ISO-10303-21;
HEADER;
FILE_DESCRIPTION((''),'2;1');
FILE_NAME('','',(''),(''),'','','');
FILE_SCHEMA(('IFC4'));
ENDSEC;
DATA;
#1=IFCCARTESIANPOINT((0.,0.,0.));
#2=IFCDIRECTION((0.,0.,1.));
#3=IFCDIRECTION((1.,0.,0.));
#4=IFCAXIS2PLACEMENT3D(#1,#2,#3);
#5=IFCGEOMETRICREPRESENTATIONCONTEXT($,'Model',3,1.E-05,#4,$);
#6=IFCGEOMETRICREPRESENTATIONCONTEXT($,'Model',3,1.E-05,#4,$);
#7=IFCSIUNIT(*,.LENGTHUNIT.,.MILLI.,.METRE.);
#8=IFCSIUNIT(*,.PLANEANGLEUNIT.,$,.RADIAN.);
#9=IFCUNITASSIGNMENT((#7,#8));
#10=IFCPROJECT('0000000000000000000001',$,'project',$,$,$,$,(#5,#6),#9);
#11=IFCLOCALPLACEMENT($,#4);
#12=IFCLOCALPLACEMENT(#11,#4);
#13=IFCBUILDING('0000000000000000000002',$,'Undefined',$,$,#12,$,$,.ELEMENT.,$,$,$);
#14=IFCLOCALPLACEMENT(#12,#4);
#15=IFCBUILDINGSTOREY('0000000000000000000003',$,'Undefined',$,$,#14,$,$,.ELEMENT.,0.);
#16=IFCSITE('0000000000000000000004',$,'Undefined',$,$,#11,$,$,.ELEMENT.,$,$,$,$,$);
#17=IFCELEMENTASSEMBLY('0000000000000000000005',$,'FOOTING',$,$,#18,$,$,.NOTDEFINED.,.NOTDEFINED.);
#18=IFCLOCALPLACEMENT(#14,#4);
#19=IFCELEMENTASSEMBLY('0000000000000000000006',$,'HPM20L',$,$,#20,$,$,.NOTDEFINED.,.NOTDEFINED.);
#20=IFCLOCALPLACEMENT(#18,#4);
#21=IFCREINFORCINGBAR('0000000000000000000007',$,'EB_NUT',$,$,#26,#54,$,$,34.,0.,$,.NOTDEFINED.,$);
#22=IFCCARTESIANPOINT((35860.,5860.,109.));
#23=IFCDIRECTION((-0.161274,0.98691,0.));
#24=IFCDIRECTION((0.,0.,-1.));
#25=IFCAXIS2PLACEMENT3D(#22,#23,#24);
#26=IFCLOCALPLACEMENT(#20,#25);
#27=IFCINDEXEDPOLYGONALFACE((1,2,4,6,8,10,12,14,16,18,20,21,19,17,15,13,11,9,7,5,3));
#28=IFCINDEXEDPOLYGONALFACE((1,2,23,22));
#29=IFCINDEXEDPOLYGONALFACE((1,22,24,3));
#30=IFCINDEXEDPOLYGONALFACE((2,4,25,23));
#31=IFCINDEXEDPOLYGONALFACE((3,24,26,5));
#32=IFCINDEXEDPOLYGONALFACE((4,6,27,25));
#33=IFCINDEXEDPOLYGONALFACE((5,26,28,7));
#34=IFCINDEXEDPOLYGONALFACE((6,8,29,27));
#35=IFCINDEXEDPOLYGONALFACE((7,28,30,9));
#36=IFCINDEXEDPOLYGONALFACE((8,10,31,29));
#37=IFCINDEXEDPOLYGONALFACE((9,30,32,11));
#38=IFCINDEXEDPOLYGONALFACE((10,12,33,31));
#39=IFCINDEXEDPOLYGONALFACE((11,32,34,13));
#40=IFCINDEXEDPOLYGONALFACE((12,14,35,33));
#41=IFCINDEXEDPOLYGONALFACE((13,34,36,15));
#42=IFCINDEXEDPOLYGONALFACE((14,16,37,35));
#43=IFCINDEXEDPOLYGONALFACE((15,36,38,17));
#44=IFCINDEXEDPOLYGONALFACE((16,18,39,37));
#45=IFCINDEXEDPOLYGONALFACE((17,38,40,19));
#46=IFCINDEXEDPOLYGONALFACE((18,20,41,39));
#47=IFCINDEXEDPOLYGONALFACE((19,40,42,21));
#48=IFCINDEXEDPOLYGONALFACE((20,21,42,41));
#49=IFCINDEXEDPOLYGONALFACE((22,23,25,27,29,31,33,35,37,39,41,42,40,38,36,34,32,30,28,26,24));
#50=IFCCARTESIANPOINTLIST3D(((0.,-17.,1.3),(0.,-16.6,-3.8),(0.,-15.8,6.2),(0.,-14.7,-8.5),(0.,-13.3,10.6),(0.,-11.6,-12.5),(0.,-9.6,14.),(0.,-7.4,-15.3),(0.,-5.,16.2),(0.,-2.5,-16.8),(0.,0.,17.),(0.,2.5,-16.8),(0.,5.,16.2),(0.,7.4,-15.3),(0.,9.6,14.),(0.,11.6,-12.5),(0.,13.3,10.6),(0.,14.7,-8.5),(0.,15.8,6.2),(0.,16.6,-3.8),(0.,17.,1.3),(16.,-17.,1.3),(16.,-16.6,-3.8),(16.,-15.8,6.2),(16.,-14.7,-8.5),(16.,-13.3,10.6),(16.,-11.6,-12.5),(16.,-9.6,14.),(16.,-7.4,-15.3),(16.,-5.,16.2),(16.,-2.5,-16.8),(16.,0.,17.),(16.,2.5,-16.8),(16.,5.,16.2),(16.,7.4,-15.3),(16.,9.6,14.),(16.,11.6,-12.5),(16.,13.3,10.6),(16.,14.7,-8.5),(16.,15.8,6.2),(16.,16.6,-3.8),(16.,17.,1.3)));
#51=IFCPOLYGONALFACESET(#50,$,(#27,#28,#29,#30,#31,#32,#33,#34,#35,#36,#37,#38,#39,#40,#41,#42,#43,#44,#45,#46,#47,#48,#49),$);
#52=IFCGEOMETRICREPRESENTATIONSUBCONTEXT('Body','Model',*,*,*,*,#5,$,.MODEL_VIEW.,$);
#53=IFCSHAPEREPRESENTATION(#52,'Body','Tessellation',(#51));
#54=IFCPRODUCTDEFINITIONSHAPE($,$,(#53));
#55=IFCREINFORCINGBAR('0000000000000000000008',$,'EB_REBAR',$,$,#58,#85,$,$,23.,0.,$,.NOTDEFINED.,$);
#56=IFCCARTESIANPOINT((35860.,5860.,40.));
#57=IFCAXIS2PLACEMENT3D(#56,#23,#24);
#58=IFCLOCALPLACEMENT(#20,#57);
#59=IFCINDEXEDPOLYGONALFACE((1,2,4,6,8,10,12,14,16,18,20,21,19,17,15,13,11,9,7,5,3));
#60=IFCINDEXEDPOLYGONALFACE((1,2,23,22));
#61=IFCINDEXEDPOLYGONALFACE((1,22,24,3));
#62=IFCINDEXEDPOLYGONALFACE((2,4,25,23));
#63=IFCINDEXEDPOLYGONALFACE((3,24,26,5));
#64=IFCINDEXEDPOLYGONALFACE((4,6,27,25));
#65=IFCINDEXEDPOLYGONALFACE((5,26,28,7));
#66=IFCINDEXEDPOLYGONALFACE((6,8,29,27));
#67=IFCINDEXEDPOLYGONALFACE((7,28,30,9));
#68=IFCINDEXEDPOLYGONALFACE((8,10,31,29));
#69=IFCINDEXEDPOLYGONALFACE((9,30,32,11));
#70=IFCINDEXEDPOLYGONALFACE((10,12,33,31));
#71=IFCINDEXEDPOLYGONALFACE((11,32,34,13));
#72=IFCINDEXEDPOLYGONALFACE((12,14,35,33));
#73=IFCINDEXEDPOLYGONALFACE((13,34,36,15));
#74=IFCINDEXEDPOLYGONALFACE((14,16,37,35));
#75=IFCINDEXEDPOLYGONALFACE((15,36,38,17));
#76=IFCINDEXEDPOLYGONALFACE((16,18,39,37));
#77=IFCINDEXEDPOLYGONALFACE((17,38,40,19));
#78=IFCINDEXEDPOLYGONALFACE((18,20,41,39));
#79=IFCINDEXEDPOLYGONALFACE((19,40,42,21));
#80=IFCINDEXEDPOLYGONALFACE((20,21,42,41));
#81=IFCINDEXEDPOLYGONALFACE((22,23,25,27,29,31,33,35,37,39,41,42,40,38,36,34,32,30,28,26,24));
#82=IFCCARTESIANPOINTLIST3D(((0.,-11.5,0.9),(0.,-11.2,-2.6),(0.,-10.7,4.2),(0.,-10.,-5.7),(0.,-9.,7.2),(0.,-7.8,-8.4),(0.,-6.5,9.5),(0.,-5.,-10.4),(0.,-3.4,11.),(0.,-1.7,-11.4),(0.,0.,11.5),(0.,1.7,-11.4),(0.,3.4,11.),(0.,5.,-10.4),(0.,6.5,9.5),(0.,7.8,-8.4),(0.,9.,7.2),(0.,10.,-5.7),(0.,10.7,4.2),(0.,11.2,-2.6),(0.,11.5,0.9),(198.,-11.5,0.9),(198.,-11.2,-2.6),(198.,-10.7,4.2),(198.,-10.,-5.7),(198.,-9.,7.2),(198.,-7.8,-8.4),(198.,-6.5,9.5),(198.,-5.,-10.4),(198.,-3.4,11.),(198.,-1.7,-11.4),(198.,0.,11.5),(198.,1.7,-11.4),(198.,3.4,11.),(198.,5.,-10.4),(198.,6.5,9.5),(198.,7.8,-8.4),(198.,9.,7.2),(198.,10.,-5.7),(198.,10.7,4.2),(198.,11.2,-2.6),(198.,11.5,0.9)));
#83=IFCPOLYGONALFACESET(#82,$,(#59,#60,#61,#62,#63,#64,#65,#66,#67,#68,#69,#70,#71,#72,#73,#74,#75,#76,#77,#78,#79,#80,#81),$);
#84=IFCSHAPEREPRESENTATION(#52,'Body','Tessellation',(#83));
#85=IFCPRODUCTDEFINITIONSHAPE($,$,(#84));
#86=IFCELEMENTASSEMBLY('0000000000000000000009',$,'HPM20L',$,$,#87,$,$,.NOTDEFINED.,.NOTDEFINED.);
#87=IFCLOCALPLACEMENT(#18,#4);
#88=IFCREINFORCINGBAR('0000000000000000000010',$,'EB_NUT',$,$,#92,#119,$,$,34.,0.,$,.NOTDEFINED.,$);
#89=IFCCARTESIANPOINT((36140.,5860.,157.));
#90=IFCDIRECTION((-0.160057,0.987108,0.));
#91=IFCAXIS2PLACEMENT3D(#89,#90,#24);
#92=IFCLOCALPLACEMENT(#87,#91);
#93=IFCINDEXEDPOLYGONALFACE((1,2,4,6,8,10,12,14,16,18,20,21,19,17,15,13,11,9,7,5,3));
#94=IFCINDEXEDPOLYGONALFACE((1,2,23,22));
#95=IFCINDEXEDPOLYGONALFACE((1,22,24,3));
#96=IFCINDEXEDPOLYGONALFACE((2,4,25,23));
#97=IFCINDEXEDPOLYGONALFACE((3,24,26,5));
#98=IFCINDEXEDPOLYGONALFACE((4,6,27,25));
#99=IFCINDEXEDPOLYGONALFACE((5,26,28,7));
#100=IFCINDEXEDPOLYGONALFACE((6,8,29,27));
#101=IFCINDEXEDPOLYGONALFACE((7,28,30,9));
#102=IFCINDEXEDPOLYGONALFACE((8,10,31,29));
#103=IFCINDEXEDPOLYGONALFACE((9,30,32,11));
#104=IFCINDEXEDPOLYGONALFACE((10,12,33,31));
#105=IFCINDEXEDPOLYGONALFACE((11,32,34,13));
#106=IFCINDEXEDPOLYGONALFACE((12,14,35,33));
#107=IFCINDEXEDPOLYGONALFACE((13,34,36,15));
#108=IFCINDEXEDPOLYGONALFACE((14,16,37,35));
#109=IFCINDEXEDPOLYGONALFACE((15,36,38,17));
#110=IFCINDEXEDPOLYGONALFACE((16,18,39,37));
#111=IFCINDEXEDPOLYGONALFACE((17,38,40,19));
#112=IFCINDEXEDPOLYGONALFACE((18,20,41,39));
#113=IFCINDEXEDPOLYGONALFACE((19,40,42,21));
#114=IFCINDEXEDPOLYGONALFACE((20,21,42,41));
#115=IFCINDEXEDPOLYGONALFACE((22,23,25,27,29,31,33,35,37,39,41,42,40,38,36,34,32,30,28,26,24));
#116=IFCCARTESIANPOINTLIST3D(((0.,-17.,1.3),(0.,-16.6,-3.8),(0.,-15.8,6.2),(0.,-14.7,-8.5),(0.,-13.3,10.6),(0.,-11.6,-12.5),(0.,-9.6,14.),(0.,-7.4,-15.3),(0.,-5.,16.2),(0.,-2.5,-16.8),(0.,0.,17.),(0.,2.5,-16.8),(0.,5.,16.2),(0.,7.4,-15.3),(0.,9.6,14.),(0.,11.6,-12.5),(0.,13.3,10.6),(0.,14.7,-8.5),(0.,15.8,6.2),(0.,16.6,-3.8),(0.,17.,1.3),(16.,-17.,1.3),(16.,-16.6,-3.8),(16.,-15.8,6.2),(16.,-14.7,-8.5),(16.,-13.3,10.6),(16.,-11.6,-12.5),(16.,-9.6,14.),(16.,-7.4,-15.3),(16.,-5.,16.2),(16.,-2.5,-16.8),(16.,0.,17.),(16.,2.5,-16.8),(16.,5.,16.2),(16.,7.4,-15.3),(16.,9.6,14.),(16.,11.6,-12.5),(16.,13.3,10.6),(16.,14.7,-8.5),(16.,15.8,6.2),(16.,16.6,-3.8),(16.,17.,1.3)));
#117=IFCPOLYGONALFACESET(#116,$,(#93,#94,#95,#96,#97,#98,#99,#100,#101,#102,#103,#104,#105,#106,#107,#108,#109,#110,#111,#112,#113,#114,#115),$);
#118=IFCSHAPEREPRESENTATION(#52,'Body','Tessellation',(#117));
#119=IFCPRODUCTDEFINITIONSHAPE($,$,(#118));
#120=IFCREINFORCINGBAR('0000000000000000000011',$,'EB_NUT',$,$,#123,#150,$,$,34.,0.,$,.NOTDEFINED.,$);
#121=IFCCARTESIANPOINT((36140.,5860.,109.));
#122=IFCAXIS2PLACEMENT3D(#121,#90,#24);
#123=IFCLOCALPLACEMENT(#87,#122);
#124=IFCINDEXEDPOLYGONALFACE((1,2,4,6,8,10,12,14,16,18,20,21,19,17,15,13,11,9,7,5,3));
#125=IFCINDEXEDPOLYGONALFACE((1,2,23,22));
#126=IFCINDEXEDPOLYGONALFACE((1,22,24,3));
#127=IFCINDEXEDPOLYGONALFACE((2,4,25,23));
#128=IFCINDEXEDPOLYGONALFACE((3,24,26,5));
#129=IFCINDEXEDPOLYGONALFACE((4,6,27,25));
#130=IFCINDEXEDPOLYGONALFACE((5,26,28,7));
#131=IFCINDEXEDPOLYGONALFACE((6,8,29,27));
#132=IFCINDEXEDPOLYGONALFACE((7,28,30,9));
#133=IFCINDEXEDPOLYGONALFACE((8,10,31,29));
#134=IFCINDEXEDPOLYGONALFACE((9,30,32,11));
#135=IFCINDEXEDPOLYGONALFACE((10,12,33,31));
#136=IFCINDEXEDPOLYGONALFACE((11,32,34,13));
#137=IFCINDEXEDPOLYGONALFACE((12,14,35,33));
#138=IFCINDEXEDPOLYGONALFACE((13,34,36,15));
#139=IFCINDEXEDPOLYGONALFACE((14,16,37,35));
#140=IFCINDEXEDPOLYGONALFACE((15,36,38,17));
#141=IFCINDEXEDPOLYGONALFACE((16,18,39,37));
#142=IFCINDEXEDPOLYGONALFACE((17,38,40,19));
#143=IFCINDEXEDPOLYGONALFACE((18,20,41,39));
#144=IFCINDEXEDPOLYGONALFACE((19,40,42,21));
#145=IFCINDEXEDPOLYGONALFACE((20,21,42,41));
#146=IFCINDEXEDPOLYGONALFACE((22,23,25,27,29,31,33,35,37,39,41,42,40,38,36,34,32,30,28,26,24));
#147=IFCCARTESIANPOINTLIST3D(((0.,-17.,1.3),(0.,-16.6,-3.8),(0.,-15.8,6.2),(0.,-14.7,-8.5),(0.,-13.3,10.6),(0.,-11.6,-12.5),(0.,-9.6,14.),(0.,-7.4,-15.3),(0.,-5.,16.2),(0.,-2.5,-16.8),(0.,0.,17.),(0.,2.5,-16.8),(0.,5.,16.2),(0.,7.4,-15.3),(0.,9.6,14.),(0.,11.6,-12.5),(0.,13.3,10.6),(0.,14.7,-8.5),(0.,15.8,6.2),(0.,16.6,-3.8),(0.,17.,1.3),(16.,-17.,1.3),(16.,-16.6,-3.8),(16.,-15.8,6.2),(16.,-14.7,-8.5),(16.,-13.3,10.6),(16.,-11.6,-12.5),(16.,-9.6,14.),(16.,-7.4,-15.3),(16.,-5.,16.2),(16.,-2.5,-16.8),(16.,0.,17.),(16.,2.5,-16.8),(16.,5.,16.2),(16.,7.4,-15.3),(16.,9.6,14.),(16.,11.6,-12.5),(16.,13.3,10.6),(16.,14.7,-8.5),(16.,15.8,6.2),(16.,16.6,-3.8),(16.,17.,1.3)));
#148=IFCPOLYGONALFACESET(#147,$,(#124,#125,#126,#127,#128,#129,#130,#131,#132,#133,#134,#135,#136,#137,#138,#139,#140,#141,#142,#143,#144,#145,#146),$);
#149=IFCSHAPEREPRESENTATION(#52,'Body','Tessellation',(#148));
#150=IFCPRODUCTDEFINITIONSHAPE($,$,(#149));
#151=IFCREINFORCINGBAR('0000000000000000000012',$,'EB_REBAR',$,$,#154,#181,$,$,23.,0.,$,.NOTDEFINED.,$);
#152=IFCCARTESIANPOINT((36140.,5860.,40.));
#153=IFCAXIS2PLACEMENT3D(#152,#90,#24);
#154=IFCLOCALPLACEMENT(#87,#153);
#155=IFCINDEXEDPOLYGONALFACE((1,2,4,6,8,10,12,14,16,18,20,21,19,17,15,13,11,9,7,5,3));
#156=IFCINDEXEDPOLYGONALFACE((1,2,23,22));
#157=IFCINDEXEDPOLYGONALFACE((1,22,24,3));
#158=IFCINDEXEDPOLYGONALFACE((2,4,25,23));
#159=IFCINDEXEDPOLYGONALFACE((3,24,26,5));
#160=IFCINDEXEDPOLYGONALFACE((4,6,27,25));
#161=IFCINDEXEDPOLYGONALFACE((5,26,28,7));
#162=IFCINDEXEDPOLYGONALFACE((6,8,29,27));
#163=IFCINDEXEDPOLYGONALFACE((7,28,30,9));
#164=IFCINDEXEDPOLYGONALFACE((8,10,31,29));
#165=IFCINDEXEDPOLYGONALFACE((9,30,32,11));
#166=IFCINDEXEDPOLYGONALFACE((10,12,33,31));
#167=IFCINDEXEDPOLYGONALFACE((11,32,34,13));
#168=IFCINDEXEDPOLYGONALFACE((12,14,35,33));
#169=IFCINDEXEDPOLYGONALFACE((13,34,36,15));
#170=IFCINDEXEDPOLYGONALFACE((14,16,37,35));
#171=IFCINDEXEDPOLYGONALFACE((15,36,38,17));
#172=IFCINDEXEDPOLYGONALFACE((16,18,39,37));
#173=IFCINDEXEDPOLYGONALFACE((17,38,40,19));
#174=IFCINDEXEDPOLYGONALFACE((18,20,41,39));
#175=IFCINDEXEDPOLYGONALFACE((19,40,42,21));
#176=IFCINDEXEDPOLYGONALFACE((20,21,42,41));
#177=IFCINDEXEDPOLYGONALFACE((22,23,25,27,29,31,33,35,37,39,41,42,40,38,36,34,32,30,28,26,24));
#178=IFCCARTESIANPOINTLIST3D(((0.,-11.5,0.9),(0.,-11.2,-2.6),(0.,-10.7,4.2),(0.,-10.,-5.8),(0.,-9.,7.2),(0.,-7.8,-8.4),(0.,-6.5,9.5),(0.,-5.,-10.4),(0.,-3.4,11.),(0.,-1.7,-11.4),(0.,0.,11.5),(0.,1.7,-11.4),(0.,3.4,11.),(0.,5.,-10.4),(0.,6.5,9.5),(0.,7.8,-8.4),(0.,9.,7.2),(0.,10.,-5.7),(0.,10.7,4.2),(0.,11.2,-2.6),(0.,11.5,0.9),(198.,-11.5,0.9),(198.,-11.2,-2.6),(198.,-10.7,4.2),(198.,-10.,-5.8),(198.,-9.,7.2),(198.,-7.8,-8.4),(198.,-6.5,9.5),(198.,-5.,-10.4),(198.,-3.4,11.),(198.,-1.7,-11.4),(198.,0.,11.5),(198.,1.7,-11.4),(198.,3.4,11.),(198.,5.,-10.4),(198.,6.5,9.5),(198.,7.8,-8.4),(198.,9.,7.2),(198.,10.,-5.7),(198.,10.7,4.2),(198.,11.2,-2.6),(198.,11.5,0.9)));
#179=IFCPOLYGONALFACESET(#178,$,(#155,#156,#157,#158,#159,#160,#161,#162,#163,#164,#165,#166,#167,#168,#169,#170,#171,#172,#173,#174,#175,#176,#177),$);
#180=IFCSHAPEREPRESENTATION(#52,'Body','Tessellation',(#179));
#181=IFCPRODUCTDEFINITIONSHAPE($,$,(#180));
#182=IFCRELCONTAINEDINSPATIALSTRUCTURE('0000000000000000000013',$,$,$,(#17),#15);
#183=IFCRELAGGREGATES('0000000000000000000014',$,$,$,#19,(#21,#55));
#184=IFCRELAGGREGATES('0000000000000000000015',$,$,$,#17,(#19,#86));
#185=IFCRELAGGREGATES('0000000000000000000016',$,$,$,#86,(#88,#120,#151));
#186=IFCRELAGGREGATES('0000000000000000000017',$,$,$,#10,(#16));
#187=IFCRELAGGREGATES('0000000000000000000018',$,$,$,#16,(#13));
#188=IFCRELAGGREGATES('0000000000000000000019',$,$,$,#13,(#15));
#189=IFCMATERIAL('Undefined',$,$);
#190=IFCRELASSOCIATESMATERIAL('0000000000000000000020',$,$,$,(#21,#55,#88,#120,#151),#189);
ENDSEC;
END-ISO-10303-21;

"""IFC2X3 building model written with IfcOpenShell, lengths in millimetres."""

from ifc_helpers import new_model, entity, si_unit, frame, origin_with_axes, place, context, subcontext, project, spatial, source, transform, mapped, material, element, aggregate, save


model = new_model("IFC2X3")

# Units and contexts
model_context_1 = context("Model", 3, precision=1e-05, world=origin_with_axes())
model_context_2 = context("Model", 3, precision=1e-05, world=origin_with_axes())
body_context = subcontext(model_context_1, "Body", "Model", "MODEL_VIEW")
ifc_project = project(units=[si_unit("LENGTHUNIT", "METRE", prefix="MILLI"), si_unit("PLANEANGLEUNIT", "RADIAN")], contexts=[model_context_1, model_context_2])

# Site, building, storey
site_placement = place(None, origin_with_axes())
site = spatial("IfcSite", under=ifc_project, at=site_placement, Name="Undefined", CompositionType="ELEMENT")
building_placement = place(site_placement, origin_with_axes())
building = spatial("IfcBuilding", under=site, at=building_placement, Name="Undefined", CompositionType="ELEMENT")
storey_placement = place(building_placement, origin_with_axes())
storey = spatial("IfcBuildingStorey", under=building, at=storey_placement, Name="Undefined", CompositionType="ELEMENT", Elevation=0.0)

# Element assembly
assembly_1_placement = place(storey_placement, origin_with_axes())
assembly_1 = element("IfcElementAssembly", 1, at=assembly_1_placement, inside=storey, Name="FOOTING", AssemblyPlace="NOTDEFINED", PredefinedType="NOTDEFINED")

# Shared definitions
ifc_material_1 = material(Name="Undefined")

# Element assembly, reinforcing bars
assembly_2_placement = place(assembly_1_placement, origin_with_axes())
assembly_2 = element("IfcElementAssembly", 2, at=assembly_2_placement, Name="HPM20L", AssemblyPlace="NOTDEFINED", PredefinedType="NOTDEFINED")
shared_shape_1 = source(origin_with_axes(), body_context, "Body", "AdvancedSweptSolid", [
    entity("IfcSweptDiskSolid", entity("IfcTrimmedCurve", entity("IfcLine", entity("IfcCartesianPoint", [0.0, 0.0, 0.0]), entity("IfcVector", entity("IfcDirection", [1.0, 0.0, 0.0]), 1.0)), [entity("IfcParameterValue", 0.0)], [entity("IfcParameterValue", 16.0)], True, "PARAMETER"), 17.0, None, 0.0, 16.0),
])
reinforcing_bar_1_placement = place(assembly_2_placement, frame((35860.0, 5860.0, 109.0), z_axis=(-0.161274, 0.98691, 0.0), x_axis=(0.0, 0.0, -1.0)))
reinforcing_bar_1 = element("IfcReinforcingBar", 3, at=reinforcing_bar_1_placement, material=ifc_material_1, Name="EB_NUT", BarRole="NOTDEFINED", CrossSectionArea=0.0, NominalDiameter=34.0, context=body_context, shape_type="MappedRepresentation", body=[
    mapped(shared_shape_1, transform((0.0, 0.0, 0.0))),
])
shared_shape_2 = source(origin_with_axes(), body_context, "Body", "AdvancedSweptSolid", [
    entity("IfcSweptDiskSolid", entity("IfcTrimmedCurve", entity("IfcLine", entity("IfcCartesianPoint", [0.0, 0.0, 0.0]), entity("IfcVector", entity("IfcDirection", [1.0, 0.0, 0.0]), 1.0)), [entity("IfcParameterValue", 0.0)], [entity("IfcParameterValue", 198.0)], True, "PARAMETER"), 11.5, None, 0.0, 198.0),
])
reinforcing_bar_2_placement = place(assembly_2_placement, frame((35860.0, 5860.0, 40.0), z_axis=(-0.161274, 0.98691, 0.0), x_axis=(0.0, 0.0, -1.0)))
reinforcing_bar_2 = element("IfcReinforcingBar", 4, at=reinforcing_bar_2_placement, material=ifc_material_1, Name="EB_REBAR", BarRole="NOTDEFINED", CrossSectionArea=0.0, NominalDiameter=23.0, context=body_context, shape_type="MappedRepresentation", body=[
    mapped(shared_shape_2, transform((0.0, 0.0, 0.0))),
])
aggregate(assembly_2, [reinforcing_bar_1, reinforcing_bar_2])

# Element assembly
assembly_3_placement = place(assembly_1_placement, origin_with_axes())
assembly_3 = element("IfcElementAssembly", 5, at=assembly_3_placement, Name="HPM20L", AssemblyPlace="NOTDEFINED", PredefinedType="NOTDEFINED")
aggregate(assembly_1, [assembly_2, assembly_3])

# Reinforcing bars
shared_shape_3 = source(origin_with_axes(), body_context, "Body", "AdvancedSweptSolid", [
    entity("IfcSweptDiskSolid", entity("IfcTrimmedCurve", entity("IfcLine", entity("IfcCartesianPoint", [0.0, 0.0, 0.0]), entity("IfcVector", entity("IfcDirection", [1.0, 0.0, 0.0]), 1.0)), [entity("IfcParameterValue", 0.0)], [entity("IfcParameterValue", 16.0)], True, "PARAMETER"), 17.0, None, 0.0, 16.0),
])
reinforcing_bar_3_placement = place(assembly_3_placement, frame((36140.0, 5860.0, 157.0), z_axis=(-0.160057, 0.987108, 0.0), x_axis=(0.0, 0.0, -1.0)))
reinforcing_bar_3 = element("IfcReinforcingBar", 6, at=reinforcing_bar_3_placement, material=ifc_material_1, Name="EB_NUT", BarRole="NOTDEFINED", CrossSectionArea=0.0, NominalDiameter=34.0, context=body_context, shape_type="MappedRepresentation", body=[
    mapped(shared_shape_3, transform((0.0, 0.0, 0.0))),
])
shared_shape_4 = source(origin_with_axes(), body_context, "Body", "AdvancedSweptSolid", [
    entity("IfcSweptDiskSolid", entity("IfcTrimmedCurve", entity("IfcLine", entity("IfcCartesianPoint", [0.0, 0.0, 0.0]), entity("IfcVector", entity("IfcDirection", [1.0, 0.0, 0.0]), 1.0)), [entity("IfcParameterValue", 0.0)], [entity("IfcParameterValue", 16.0)], True, "PARAMETER"), 17.0, None, 0.0, 16.0),
])
reinforcing_bar_4_placement = place(assembly_3_placement, frame((36140.0, 5860.0, 109.0), z_axis=(-0.160057, 0.987108, 0.0), x_axis=(0.0, 0.0, -1.0)))
reinforcing_bar_4 = element("IfcReinforcingBar", 7, at=reinforcing_bar_4_placement, material=ifc_material_1, Name="EB_NUT", BarRole="NOTDEFINED", CrossSectionArea=0.0, NominalDiameter=34.0, context=body_context, shape_type="MappedRepresentation", body=[
    mapped(shared_shape_4, transform((0.0, 0.0, 0.0))),
])
shared_shape_5 = source(origin_with_axes(), body_context, "Body", "AdvancedSweptSolid", [
    entity("IfcSweptDiskSolid", entity("IfcTrimmedCurve", entity("IfcLine", entity("IfcCartesianPoint", [0.0, 0.0, 0.0]), entity("IfcVector", entity("IfcDirection", [1.0, 0.0, 0.0]), 1.0)), [entity("IfcParameterValue", 0.0)], [entity("IfcParameterValue", 198.0)], True, "PARAMETER"), 11.5, None, 0.0, 198.0),
])
reinforcing_bar_5_placement = place(assembly_3_placement, frame((36140.0, 5860.0, 40.0), z_axis=(-0.160057, 0.987108, 0.0), x_axis=(0.0, 0.0, -1.0)))
reinforcing_bar_5 = element("IfcReinforcingBar", 8, at=reinforcing_bar_5_placement, material=ifc_material_1, Name="EB_REBAR", BarRole="NOTDEFINED", CrossSectionArea=0.0, NominalDiameter=23.0, context=body_context, shape_type="MappedRepresentation", body=[
    mapped(shared_shape_5, transform((0.0, 0.0, 0.0))),
])
aggregate(assembly_3, [reinforcing_bar_3, reinforcing_bar_4, reinforcing_bar_5])

save(model, "model.ifc")
